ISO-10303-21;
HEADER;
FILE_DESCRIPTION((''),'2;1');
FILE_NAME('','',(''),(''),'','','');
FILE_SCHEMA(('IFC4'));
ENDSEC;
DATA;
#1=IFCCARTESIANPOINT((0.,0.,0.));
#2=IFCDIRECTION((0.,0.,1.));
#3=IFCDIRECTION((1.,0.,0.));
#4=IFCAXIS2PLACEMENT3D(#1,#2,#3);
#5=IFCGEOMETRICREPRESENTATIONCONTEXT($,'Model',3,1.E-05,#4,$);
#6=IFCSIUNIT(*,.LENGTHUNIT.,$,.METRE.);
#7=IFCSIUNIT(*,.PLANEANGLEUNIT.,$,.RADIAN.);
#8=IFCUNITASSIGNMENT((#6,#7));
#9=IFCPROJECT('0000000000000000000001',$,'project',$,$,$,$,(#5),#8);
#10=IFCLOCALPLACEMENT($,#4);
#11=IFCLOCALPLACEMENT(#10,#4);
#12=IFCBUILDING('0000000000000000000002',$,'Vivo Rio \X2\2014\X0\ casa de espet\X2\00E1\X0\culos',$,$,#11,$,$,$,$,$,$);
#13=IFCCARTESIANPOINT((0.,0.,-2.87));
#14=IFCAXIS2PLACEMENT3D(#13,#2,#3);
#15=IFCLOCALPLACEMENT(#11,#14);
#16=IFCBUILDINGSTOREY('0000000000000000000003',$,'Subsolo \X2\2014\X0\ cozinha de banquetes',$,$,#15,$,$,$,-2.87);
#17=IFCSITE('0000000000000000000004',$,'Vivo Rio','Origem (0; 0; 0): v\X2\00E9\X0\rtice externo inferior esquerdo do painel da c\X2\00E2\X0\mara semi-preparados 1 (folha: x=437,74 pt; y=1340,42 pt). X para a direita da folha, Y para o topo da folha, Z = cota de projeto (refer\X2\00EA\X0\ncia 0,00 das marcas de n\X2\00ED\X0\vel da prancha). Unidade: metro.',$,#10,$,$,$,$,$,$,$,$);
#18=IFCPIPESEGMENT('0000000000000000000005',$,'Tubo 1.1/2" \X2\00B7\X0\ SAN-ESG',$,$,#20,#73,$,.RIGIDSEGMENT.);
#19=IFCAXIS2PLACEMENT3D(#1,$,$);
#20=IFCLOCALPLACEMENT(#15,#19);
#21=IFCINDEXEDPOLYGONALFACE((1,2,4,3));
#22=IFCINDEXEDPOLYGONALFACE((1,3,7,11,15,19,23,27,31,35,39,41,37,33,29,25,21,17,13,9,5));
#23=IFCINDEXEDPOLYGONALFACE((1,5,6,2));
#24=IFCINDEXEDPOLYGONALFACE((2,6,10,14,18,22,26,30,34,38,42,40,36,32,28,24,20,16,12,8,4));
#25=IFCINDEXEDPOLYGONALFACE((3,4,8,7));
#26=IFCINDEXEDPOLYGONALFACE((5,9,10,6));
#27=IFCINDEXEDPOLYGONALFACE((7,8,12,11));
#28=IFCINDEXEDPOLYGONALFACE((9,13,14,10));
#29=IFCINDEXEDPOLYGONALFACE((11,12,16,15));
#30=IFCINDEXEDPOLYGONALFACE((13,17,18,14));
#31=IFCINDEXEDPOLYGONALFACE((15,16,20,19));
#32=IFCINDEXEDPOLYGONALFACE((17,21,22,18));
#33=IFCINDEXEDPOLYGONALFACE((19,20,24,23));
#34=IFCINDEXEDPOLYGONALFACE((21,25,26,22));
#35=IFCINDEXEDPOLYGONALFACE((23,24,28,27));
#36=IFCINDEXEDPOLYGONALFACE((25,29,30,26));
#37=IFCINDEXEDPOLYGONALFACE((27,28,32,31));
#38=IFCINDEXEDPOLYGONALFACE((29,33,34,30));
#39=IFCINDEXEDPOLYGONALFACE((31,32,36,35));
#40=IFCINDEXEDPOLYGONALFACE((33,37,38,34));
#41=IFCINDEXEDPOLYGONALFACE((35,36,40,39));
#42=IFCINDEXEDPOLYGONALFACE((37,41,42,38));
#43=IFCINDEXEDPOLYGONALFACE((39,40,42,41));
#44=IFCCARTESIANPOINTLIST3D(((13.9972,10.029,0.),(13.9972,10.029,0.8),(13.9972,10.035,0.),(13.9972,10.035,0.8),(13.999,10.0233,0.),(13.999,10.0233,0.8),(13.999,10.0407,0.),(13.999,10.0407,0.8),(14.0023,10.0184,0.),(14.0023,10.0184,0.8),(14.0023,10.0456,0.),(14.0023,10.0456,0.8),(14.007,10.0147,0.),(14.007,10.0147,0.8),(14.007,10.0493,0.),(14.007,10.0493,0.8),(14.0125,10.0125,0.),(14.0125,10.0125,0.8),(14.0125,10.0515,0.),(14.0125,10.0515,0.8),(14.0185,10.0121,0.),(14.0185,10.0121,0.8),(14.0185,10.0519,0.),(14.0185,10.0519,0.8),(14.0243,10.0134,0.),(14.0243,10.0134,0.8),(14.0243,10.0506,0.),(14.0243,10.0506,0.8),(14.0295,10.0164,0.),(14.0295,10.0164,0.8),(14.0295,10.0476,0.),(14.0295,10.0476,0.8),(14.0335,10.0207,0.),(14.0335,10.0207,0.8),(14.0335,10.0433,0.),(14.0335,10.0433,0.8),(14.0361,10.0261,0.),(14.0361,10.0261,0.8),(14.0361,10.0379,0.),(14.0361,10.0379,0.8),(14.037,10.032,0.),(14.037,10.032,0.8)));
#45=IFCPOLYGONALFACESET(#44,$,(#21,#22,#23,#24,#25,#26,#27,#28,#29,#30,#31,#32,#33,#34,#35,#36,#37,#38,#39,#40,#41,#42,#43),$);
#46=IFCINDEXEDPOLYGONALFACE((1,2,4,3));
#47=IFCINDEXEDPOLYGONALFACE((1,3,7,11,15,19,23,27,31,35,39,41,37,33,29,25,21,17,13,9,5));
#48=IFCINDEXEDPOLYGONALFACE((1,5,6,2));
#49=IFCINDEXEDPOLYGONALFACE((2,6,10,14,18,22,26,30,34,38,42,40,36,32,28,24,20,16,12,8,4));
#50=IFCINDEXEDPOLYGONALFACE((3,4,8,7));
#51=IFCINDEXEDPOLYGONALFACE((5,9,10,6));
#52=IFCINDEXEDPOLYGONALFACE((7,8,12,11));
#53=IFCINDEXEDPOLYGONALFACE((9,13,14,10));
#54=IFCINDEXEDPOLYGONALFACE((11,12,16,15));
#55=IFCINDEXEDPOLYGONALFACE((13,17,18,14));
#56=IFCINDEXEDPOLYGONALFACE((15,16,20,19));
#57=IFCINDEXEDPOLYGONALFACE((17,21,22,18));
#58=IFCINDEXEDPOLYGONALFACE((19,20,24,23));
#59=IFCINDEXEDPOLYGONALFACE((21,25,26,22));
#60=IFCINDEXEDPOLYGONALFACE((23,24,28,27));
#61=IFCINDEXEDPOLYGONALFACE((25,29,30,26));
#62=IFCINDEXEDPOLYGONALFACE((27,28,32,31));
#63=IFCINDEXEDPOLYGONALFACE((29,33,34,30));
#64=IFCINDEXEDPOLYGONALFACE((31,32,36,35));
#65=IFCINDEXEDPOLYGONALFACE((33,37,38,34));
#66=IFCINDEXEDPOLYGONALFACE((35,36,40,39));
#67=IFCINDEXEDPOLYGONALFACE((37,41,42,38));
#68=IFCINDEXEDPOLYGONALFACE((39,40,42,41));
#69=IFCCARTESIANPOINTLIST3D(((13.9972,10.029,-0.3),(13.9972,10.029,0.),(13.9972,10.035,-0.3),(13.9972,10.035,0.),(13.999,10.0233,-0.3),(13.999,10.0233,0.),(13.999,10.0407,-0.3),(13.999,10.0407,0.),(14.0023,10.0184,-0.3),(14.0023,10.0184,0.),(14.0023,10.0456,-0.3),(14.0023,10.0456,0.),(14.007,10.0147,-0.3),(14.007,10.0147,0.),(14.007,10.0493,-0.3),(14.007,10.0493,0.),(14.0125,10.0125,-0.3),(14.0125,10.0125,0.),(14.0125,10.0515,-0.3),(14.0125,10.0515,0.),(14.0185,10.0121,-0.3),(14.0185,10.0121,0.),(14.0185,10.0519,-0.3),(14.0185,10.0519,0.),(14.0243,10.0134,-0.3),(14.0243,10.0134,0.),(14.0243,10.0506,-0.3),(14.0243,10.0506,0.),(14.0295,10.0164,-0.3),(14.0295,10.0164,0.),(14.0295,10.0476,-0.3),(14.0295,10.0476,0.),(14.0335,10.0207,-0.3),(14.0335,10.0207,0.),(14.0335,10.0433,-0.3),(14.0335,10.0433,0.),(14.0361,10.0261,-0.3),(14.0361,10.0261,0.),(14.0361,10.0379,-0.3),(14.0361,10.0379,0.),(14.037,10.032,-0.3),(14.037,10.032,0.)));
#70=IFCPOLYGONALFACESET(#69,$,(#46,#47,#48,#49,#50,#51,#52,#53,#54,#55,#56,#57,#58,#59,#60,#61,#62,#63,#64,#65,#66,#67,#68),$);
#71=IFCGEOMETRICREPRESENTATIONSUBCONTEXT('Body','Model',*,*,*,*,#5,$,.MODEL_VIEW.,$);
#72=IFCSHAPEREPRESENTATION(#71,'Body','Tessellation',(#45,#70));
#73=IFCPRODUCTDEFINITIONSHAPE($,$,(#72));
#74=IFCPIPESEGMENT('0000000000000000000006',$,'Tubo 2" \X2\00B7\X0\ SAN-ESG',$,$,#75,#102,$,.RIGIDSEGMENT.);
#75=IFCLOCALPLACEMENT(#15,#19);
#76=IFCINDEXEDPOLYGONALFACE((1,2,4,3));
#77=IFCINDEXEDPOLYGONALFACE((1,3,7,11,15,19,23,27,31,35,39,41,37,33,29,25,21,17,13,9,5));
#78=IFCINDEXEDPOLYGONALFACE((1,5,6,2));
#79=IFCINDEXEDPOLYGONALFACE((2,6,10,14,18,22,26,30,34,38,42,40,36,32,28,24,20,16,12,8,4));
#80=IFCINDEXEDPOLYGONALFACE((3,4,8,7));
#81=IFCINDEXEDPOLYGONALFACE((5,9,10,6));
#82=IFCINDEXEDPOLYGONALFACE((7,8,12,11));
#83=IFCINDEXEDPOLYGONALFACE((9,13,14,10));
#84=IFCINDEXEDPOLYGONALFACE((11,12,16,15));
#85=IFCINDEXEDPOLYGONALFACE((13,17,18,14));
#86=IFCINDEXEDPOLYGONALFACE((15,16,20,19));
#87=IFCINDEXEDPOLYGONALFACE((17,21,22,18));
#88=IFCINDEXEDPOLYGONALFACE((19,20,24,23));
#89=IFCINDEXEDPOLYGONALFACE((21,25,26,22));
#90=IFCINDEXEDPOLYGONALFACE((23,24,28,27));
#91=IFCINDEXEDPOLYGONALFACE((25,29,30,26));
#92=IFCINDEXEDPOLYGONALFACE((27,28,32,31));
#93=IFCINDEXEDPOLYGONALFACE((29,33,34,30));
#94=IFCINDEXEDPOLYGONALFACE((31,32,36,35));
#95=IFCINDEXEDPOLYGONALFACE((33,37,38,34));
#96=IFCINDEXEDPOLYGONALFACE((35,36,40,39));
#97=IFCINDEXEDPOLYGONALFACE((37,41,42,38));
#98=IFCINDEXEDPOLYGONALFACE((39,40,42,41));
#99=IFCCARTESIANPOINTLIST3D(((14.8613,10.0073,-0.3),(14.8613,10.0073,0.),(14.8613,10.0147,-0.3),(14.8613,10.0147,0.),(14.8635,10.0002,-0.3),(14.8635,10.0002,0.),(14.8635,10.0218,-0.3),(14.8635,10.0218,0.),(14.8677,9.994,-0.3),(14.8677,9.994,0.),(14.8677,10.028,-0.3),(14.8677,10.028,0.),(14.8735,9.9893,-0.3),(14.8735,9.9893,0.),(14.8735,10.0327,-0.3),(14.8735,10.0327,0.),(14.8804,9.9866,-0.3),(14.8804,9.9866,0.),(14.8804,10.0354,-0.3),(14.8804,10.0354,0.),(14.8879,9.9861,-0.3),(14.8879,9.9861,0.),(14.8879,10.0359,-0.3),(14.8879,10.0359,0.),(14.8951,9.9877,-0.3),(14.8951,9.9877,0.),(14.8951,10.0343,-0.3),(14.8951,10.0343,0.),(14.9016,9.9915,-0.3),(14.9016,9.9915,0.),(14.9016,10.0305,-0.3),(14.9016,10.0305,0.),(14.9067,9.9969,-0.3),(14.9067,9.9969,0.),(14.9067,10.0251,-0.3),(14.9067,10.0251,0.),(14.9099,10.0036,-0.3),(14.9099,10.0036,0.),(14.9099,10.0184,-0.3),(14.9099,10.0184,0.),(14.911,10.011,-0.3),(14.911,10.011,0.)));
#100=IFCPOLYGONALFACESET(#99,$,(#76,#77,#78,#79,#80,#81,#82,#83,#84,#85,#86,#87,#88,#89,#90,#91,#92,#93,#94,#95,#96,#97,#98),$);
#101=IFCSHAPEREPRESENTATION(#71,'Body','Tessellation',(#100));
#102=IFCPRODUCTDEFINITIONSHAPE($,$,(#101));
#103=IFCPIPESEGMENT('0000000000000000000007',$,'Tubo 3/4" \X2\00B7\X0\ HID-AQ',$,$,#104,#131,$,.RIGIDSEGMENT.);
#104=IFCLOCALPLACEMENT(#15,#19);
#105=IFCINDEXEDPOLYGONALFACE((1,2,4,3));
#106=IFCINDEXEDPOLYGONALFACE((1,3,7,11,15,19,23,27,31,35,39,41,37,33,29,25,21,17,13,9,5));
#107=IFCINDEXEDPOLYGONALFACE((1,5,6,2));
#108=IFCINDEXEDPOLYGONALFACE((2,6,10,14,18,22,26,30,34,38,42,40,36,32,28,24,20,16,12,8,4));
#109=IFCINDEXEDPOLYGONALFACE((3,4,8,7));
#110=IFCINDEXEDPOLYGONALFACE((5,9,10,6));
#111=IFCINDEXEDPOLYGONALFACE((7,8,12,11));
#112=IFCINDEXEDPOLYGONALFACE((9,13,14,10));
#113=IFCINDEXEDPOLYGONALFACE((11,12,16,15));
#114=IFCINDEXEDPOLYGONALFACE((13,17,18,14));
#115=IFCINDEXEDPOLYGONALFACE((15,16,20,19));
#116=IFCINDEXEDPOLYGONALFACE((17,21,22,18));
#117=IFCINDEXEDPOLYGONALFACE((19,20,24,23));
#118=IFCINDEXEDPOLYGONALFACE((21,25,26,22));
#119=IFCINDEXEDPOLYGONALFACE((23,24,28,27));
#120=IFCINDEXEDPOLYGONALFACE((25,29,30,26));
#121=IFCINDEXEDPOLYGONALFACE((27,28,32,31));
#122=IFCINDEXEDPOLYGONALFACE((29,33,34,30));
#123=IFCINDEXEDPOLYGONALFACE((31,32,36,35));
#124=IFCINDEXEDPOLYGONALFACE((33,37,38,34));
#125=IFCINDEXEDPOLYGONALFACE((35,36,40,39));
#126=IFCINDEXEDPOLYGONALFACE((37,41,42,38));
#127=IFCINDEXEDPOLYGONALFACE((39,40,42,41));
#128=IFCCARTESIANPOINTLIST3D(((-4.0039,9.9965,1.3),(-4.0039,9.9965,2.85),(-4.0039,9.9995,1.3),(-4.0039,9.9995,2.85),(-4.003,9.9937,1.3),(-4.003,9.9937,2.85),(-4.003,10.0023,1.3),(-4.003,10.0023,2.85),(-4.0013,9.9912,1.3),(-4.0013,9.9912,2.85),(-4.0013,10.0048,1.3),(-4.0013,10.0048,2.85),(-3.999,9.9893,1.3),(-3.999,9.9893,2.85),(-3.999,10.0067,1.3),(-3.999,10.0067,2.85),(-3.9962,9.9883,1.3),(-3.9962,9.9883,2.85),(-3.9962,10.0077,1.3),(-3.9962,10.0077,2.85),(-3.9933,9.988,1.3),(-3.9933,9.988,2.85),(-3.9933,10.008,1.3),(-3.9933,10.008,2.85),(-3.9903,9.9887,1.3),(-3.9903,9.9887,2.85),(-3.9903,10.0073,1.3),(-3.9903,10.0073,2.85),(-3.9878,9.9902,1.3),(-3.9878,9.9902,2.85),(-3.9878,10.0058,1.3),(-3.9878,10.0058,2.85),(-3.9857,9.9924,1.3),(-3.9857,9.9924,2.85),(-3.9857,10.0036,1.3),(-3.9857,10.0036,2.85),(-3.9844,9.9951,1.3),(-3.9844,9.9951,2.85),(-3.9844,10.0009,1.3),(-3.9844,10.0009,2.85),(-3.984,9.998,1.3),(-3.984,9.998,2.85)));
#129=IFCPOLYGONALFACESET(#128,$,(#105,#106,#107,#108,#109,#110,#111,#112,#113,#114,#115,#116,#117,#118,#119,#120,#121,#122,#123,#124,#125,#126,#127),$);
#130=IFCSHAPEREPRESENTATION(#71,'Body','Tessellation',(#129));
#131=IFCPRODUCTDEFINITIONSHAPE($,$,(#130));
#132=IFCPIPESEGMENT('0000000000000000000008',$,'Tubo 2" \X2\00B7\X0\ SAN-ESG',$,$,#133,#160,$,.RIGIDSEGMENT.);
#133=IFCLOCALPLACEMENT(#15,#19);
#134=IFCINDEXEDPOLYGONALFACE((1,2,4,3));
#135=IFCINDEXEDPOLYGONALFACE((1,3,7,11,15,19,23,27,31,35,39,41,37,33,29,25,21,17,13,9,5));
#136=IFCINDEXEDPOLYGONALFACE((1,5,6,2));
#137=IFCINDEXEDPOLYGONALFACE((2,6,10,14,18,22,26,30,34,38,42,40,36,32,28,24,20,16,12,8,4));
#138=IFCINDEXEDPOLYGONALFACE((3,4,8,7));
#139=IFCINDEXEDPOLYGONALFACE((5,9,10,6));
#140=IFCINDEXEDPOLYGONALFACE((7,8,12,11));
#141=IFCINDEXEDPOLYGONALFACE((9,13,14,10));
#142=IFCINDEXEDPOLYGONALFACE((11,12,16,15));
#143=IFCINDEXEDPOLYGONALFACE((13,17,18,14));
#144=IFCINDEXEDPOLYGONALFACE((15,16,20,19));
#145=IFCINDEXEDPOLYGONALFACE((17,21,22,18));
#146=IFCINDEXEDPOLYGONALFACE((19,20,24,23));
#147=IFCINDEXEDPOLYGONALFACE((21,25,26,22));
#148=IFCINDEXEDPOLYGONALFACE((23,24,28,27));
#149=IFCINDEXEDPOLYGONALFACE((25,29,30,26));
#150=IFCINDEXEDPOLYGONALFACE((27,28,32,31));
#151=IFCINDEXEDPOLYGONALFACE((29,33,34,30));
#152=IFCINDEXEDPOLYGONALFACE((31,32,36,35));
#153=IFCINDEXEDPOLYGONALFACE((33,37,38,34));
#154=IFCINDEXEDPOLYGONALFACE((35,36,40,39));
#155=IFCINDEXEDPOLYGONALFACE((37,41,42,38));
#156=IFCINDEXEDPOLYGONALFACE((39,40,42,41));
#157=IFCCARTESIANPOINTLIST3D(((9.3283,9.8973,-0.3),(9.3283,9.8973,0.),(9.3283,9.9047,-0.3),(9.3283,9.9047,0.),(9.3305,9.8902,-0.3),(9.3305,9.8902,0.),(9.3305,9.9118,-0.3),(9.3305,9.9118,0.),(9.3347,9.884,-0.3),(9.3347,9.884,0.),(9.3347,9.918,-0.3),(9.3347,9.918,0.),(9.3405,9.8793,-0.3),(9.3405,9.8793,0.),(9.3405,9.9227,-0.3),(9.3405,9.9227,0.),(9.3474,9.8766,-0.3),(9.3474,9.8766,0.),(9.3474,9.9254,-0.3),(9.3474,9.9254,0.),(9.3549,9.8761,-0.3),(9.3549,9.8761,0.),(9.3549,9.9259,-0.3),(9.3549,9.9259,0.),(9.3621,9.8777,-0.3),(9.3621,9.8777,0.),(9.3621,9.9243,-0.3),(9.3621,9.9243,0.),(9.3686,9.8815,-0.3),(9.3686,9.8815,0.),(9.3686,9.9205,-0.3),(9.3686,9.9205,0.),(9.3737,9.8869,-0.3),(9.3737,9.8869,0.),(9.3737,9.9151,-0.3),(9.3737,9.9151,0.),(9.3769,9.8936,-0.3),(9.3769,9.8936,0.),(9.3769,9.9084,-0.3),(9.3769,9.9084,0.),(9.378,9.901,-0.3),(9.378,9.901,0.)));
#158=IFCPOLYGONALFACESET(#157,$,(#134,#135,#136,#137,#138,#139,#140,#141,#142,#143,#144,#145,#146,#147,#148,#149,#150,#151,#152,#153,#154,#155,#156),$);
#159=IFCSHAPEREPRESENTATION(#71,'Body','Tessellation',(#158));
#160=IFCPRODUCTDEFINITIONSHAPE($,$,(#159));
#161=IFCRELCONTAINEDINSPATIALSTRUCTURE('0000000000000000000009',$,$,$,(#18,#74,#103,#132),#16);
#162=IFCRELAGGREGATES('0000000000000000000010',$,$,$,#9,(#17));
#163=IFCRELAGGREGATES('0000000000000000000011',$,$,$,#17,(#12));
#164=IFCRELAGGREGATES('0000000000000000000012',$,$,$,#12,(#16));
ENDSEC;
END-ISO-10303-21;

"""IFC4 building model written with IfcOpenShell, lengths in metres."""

from ifc_helpers import new_model, si_unit, frame, origin_with_axes, origin_2d, place, context, subcontext, project, spatial, circle, extrude, element, save


model = new_model("IFC4")

# Units and contexts
model_context = context("Model", 3, precision=1e-05, world=origin_with_axes())
body_context = subcontext(model_context, "Body", "Model", "MODEL_VIEW")
ifc_project = project(units=[si_unit("LENGTHUNIT", "METRE"), si_unit("PLANEANGLEUNIT", "RADIAN")], contexts=[model_context])

# Site, building, storey
site_placement = place(None, origin_with_axes())
site = spatial("IfcSite", under=ifc_project, at=site_placement, Name="Vivo Rio", Description="Origem (0; 0; 0): vértice externo inferior esquerdo do painel da câmara semi-preparados 1 (folha: x=437,74 pt; y=1340,42 pt). X para a direita da folha, Y para o topo da folha, Z = cota de projeto (referência 0,00 das marcas de nível da prancha). Unidade: metro.")
building_placement = place(site_placement, origin_with_axes())
building = spatial("IfcBuilding", under=site, at=building_placement, Name="Vivo Rio — casa de espetáculos")
storey_placement = place(building_placement, frame((0.0, 0.0, -2.87), z_axis=(0.0, 0.0, 1.0), x_axis=(1.0, 0.0, 0.0)))
storey = spatial("IfcBuildingStorey", under=building, at=storey_placement, Name="Subsolo — cozinha de banquetes", Elevation=-2.87)

# Pipe segments
pipe_segment_1_placement = place(storey_placement, origin_with_axes())
element("IfcPipeSegment", 1, at=pipe_segment_1_placement, inside=storey, Name="Tubo 1.1/2\" · SAN-ESG", PredefinedType="RIGIDSEGMENT", context=body_context, shape_type="SweptSolid", body=[
    extrude(circle(Radius=0.02, at=origin_2d()), frame((14.017, 10.032, 0.8), z_axis=(0.0, 0.0, -1.0), x_axis=(1.0, 0.0, 0.0)), (0.0, 0.0, 1.0), 0.8),
    extrude(circle(Radius=0.02, at=origin_2d()), frame((14.017, 10.032, 0.0), z_axis=(0.0, 0.0, -1.0), x_axis=(1.0, 0.0, 0.0)), (0.0, 0.0, 1.0), 0.3),
])
pipe_segment_2_placement = place(storey_placement, origin_with_axes())
element("IfcPipeSegment", 2, at=pipe_segment_2_placement, inside=storey, Name="Tubo 2\" · SAN-ESG", PredefinedType="RIGIDSEGMENT", context=body_context, shape_type="SweptSolid", body=[
    extrude(circle(Radius=0.025, at=origin_2d()), frame((14.886, 10.011, 0.0), z_axis=(0.0, 0.0, -1.0), x_axis=(1.0, 0.0, 0.0)), (0.0, 0.0, 1.0), 0.3),
])
pipe_segment_3_placement = place(storey_placement, origin_with_axes())
element("IfcPipeSegment", 3, at=pipe_segment_3_placement, inside=storey, Name="Tubo 3/4\" · HID-AQ", PredefinedType="RIGIDSEGMENT", context=body_context, shape_type="SweptSolid", body=[
    extrude(circle(Radius=0.01, at=origin_2d()), frame((-3.994, 9.998, 2.85), z_axis=(0.0, 0.0, -1.0), x_axis=(1.0, 0.0, 0.0)), (0.0, 0.0, 1.0), 1.55),
])
pipe_segment_4_placement = place(storey_placement, origin_with_axes())
element("IfcPipeSegment", 4, at=pipe_segment_4_placement, inside=storey, Name="Tubo 2\" · SAN-ESG", PredefinedType="RIGIDSEGMENT", context=body_context, shape_type="SweptSolid", body=[
    extrude(circle(Radius=0.025, at=origin_2d()), frame((9.353, 9.901, 0.0), z_axis=(0.0, 0.0, -1.0), x_axis=(1.0, 0.0, 0.0)), (0.0, 0.0, 1.0), 0.3),
])

save(model, "model.ifc")
